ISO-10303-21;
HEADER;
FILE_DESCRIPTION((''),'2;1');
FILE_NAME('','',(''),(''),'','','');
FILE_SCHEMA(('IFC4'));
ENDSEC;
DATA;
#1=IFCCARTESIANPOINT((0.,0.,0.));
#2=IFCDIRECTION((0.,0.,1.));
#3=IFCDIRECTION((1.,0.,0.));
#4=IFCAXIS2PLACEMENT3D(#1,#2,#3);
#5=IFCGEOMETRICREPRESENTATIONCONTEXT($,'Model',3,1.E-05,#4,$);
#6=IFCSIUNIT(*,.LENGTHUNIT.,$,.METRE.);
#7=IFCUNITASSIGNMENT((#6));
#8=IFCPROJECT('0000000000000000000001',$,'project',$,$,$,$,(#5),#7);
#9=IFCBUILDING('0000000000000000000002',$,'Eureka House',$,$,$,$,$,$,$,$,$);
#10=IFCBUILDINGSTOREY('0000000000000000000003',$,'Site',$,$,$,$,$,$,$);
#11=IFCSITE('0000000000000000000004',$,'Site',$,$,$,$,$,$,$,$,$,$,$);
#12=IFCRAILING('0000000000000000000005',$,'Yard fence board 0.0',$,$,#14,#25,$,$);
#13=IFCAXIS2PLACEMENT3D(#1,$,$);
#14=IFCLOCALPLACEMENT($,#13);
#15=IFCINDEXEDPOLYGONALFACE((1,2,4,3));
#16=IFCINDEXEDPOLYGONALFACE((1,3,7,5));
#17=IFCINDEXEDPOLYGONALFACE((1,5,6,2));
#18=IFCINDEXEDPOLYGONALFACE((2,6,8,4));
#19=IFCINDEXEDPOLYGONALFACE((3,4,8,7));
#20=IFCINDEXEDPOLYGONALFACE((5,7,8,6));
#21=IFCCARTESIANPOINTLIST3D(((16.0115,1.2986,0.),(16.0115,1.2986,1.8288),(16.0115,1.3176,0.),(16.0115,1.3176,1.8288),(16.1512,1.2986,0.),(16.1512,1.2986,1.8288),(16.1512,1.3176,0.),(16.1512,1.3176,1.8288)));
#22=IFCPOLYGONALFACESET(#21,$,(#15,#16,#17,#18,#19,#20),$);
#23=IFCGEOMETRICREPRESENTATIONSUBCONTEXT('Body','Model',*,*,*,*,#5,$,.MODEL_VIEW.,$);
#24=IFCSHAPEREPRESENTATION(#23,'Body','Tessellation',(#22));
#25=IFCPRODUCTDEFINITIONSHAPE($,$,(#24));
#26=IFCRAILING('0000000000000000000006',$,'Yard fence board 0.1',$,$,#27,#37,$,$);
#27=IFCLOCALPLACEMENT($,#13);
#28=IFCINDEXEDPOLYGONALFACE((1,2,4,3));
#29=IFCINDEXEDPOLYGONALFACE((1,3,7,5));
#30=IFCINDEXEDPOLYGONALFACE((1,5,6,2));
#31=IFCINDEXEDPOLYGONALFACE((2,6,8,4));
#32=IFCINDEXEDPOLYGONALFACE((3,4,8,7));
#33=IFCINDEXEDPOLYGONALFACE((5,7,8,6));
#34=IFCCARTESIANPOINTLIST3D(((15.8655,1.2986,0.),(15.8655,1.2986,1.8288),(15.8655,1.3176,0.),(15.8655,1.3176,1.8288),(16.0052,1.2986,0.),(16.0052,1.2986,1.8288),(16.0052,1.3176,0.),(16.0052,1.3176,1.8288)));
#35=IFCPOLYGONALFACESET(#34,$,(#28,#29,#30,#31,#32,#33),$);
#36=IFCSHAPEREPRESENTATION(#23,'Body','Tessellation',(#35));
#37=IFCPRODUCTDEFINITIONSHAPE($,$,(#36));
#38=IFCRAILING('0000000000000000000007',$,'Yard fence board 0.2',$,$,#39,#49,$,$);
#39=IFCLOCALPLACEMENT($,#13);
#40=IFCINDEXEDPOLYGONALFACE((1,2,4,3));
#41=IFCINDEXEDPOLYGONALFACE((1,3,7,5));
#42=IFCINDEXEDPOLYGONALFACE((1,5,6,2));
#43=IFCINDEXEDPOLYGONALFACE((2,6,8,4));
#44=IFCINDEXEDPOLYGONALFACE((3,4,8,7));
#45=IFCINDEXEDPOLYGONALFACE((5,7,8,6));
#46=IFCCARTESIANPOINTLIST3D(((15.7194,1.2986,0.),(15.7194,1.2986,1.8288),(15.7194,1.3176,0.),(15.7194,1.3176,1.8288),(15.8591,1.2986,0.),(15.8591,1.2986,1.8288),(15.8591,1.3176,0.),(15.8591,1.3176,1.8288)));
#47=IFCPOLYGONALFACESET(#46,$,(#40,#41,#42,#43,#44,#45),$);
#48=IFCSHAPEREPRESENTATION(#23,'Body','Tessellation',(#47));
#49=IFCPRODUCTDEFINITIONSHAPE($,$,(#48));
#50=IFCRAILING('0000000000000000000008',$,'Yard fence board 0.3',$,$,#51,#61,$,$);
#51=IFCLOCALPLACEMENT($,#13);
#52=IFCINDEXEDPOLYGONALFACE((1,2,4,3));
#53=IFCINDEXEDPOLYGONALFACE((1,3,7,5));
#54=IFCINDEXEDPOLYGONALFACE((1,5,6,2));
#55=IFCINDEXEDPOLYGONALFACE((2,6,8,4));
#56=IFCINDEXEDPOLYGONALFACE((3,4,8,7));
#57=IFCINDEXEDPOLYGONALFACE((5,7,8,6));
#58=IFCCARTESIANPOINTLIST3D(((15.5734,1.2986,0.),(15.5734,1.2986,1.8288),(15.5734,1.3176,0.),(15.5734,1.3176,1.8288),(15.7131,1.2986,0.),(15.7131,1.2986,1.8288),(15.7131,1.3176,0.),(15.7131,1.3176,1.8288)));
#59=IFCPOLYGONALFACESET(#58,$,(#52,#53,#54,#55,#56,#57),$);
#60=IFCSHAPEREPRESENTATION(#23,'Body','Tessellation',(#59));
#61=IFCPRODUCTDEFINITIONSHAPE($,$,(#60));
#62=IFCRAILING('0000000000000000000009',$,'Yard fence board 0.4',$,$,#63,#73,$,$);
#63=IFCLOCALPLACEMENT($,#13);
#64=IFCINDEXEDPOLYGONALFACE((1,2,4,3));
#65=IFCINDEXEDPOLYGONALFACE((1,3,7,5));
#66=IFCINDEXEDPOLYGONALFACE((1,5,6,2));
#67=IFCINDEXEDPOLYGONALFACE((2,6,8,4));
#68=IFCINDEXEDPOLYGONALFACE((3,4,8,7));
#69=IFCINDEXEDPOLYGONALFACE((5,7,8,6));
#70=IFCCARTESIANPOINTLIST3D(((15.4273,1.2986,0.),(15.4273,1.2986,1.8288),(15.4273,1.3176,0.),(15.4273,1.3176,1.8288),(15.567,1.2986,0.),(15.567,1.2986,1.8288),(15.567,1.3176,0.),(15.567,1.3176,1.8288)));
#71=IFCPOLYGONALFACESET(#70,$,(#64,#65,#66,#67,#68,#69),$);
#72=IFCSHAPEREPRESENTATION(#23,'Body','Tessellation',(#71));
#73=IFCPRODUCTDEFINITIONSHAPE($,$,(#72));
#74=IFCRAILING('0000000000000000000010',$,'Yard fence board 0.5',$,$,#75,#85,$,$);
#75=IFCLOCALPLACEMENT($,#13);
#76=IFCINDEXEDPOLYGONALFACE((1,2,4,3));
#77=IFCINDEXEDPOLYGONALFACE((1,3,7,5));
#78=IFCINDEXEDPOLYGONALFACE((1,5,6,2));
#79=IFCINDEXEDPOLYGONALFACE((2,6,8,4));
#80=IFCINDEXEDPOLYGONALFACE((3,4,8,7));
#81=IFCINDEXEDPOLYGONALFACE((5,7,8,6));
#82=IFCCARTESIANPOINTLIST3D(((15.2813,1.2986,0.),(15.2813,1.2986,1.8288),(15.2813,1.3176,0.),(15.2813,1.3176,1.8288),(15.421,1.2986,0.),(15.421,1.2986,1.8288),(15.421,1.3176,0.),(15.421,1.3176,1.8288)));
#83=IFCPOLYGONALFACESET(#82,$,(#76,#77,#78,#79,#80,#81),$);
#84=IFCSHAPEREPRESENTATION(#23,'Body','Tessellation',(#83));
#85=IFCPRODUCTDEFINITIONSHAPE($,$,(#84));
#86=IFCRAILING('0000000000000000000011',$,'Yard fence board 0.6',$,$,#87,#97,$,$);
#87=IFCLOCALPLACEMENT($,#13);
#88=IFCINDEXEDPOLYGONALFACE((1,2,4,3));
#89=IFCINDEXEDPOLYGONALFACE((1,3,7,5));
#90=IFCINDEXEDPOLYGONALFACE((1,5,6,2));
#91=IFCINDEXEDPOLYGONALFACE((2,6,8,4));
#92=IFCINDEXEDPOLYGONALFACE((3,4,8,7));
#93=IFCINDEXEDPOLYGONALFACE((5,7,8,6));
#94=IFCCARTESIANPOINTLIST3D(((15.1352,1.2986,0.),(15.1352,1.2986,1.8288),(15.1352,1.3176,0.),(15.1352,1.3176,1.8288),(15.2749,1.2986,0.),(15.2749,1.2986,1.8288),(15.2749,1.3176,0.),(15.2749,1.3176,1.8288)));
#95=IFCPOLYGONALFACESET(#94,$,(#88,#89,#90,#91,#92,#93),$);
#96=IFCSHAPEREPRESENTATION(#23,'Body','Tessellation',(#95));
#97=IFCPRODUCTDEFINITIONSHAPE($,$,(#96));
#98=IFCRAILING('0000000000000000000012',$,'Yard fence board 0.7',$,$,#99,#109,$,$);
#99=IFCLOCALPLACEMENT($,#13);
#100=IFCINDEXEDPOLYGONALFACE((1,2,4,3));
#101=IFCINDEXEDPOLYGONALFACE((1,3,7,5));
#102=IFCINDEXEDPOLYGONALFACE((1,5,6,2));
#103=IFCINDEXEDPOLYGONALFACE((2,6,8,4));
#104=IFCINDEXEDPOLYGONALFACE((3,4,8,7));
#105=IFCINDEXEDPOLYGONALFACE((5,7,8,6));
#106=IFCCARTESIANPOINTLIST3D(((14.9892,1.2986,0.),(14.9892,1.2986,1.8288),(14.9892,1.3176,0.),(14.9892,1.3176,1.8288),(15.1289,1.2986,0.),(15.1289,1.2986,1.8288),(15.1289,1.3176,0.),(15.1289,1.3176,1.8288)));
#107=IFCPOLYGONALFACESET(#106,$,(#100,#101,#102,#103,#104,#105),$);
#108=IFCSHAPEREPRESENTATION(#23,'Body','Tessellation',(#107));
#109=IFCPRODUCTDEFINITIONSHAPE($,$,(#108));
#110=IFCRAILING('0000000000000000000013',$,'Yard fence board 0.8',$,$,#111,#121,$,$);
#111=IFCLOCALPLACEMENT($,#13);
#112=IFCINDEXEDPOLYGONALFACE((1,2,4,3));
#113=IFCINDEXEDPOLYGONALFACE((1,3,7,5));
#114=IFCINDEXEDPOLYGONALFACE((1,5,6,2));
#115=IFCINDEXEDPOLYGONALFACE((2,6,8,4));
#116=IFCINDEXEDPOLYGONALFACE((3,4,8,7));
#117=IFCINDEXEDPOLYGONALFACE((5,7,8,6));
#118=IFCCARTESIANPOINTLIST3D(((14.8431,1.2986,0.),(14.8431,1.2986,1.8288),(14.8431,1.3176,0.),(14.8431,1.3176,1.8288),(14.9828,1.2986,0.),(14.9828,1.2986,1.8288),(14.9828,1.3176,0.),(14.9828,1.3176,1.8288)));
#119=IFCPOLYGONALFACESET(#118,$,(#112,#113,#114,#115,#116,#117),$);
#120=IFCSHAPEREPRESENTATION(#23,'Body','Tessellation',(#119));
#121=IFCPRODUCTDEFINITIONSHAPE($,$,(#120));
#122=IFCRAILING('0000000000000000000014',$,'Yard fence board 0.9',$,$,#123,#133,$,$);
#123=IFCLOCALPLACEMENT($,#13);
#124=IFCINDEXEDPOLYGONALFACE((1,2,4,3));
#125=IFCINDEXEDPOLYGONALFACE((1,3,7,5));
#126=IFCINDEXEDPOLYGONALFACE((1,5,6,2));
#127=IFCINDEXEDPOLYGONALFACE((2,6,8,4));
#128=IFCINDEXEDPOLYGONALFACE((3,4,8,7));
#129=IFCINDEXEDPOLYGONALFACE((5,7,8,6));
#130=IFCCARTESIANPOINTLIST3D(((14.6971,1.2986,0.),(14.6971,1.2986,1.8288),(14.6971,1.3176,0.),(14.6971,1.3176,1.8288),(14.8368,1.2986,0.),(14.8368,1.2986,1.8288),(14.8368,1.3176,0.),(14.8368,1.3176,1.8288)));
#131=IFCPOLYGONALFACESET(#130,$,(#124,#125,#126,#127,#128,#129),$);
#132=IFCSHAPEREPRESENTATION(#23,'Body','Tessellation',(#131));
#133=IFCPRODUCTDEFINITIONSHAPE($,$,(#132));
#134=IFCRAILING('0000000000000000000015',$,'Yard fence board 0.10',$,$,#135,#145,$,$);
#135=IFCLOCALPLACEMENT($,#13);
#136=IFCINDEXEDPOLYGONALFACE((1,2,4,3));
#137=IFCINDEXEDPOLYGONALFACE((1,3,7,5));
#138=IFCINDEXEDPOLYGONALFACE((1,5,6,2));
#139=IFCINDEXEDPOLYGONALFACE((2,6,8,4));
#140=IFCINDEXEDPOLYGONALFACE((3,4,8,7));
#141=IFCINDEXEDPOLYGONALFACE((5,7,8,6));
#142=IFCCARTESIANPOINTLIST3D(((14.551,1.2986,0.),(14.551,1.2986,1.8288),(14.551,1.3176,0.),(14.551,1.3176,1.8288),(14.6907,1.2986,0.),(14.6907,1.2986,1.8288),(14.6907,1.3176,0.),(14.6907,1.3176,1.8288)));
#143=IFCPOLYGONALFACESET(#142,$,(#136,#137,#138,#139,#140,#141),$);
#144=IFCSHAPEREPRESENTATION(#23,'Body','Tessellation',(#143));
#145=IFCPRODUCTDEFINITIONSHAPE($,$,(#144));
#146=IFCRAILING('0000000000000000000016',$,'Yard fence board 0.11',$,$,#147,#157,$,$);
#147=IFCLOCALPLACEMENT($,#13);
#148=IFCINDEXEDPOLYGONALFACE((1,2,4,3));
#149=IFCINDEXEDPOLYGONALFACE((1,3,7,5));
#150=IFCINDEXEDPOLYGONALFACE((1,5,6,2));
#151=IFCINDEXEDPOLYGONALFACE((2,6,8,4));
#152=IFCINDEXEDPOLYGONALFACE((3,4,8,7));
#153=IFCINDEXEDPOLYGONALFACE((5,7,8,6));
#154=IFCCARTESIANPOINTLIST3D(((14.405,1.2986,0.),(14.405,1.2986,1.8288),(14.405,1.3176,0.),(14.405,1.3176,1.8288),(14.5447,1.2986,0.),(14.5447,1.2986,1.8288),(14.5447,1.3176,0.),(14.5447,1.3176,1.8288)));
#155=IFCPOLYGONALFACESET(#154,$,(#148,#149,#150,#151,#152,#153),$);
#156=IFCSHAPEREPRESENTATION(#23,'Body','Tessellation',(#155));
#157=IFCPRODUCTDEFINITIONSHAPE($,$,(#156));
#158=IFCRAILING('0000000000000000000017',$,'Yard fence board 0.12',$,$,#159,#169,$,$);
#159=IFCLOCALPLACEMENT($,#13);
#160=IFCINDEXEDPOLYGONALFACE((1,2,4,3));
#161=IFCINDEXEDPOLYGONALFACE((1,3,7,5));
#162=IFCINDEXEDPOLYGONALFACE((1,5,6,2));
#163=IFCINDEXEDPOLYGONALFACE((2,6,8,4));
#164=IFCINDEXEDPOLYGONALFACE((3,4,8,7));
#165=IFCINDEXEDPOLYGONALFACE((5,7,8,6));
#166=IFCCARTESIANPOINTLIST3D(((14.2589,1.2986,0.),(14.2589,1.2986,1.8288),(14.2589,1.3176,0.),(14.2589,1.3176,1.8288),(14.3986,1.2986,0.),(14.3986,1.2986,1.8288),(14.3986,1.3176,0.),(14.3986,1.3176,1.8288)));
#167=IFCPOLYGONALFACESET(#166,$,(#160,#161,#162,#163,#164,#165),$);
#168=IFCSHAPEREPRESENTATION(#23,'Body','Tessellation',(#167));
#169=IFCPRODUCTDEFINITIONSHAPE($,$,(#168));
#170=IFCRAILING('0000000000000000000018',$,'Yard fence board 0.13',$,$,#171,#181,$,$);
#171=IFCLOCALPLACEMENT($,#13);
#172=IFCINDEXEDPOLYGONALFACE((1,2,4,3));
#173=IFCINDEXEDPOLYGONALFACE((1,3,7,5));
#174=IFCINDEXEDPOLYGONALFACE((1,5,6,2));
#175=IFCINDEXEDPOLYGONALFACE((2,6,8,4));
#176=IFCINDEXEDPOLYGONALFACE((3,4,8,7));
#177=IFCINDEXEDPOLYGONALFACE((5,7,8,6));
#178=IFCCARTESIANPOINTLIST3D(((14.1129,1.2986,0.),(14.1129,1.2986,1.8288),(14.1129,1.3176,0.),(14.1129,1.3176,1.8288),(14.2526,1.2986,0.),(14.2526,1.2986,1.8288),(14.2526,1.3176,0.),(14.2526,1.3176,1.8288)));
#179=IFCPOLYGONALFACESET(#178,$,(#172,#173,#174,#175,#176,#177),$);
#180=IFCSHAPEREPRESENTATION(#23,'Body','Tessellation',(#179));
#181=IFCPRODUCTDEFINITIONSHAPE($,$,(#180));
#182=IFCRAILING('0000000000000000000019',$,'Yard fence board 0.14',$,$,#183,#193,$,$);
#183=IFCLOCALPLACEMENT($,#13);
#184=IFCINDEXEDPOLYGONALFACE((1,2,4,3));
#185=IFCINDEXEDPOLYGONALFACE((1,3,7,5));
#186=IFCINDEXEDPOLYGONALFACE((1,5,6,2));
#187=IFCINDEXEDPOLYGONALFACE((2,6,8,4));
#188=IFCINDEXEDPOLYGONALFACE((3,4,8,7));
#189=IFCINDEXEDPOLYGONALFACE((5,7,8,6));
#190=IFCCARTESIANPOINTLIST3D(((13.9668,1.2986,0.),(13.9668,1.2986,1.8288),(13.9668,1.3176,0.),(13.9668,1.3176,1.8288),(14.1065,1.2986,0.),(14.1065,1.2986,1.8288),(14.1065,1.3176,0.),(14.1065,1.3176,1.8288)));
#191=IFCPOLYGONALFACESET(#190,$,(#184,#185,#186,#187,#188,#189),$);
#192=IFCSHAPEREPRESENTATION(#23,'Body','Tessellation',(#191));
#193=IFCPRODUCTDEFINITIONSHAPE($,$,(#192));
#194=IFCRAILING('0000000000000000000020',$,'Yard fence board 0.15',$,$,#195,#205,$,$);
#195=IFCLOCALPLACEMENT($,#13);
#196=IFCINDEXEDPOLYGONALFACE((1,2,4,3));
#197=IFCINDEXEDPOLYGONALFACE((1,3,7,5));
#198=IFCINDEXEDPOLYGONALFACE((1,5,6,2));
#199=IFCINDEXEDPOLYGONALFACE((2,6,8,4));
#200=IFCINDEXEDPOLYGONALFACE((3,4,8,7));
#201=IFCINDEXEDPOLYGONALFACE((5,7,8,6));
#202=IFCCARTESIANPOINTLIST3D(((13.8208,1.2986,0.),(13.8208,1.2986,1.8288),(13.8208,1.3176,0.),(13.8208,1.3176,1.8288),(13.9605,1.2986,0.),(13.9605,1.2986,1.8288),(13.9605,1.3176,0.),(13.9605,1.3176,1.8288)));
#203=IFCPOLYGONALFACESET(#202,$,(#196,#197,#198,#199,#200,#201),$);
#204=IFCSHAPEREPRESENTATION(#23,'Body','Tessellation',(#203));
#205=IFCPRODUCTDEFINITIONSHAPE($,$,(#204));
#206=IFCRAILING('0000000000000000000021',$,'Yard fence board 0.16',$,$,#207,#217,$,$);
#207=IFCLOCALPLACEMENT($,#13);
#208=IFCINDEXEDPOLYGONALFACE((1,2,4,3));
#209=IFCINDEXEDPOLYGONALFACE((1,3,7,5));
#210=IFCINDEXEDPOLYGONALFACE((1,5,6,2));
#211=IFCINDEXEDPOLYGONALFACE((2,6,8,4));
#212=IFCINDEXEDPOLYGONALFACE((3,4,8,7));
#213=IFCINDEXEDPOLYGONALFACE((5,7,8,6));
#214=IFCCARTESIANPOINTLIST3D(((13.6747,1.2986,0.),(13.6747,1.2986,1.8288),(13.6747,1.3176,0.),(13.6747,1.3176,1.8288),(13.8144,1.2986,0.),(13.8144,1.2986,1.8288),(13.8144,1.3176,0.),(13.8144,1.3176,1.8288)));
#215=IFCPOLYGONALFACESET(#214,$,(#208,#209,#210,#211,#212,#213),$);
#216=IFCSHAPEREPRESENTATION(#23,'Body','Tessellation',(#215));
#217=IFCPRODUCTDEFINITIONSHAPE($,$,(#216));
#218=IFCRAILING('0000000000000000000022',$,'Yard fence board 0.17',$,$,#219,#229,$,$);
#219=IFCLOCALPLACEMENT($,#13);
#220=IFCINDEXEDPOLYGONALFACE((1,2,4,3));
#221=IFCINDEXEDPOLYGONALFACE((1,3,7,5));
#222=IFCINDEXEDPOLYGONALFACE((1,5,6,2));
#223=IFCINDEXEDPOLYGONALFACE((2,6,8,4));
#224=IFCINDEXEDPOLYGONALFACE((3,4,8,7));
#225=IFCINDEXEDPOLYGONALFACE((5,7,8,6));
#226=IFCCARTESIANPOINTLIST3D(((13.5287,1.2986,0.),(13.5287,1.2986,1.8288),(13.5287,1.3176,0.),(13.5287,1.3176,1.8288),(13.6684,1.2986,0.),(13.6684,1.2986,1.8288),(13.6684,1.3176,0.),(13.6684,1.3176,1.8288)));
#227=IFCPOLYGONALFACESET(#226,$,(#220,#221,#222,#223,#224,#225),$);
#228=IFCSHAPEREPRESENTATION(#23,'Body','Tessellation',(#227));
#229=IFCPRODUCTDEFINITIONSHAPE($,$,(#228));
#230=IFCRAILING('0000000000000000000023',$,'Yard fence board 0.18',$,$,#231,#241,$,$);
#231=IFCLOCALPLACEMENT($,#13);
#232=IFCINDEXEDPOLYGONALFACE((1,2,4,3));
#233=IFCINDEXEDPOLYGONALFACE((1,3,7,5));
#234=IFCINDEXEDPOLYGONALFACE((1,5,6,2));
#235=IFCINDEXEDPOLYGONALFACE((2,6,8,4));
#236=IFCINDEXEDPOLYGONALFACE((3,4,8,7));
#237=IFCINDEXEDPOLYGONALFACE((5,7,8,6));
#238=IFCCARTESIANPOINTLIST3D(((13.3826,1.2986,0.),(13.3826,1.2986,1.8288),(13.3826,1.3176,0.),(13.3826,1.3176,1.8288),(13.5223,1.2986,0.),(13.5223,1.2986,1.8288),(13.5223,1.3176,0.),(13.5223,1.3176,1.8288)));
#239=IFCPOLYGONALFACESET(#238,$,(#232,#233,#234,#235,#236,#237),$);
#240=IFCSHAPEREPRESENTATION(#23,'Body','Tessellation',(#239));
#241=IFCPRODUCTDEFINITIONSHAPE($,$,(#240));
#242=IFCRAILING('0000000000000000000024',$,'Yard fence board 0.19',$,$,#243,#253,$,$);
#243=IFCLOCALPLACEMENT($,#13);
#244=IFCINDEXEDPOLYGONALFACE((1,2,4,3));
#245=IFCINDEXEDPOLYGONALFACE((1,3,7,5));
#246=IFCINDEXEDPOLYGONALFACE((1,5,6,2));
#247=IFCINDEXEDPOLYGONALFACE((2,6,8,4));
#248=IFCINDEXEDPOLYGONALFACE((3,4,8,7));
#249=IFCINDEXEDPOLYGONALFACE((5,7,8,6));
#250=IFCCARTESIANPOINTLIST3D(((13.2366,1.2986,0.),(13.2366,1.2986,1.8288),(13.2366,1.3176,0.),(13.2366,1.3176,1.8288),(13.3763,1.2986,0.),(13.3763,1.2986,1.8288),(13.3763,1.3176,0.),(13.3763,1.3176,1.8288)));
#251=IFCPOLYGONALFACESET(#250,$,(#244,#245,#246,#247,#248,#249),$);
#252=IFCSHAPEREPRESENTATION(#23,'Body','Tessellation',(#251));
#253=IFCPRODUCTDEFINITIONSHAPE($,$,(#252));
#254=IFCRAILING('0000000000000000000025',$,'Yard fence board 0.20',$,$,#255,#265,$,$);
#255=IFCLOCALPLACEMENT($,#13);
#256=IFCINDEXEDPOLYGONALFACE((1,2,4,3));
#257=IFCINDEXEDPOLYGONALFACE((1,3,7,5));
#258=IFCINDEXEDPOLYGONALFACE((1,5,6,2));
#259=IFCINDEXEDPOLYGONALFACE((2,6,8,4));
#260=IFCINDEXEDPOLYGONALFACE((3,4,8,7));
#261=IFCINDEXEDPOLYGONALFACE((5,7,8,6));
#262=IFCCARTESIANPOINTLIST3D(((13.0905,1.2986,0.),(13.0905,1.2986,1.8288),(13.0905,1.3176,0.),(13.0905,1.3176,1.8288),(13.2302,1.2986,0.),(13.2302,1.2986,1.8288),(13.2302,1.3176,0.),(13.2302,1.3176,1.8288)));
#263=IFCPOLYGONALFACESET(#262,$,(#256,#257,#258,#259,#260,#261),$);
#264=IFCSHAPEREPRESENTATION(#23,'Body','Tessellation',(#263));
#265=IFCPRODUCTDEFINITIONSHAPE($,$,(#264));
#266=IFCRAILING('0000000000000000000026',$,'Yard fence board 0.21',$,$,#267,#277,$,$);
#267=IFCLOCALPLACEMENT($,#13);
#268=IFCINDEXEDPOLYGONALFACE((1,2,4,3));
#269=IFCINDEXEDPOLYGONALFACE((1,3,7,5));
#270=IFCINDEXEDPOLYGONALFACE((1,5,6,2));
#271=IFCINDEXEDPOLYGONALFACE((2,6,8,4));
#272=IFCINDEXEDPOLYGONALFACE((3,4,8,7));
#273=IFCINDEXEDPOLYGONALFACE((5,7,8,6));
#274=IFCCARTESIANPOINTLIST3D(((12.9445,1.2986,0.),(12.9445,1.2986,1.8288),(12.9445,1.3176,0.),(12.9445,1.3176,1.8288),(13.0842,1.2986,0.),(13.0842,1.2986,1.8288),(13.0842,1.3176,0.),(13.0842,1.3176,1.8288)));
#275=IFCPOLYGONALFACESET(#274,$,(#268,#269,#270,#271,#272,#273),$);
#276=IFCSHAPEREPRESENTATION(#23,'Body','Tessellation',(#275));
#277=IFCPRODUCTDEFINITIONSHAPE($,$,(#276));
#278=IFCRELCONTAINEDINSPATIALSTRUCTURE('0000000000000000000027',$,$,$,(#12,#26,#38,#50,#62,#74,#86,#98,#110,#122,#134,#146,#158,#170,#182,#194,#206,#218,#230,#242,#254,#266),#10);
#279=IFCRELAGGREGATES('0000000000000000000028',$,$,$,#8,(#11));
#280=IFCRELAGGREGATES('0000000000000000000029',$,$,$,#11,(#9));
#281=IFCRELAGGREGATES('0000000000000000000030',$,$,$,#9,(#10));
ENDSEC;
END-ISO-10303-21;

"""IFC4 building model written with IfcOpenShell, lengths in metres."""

from ifc_helpers import new_model, si_unit, frame, origin, origin_with_axes, origin_2d, place, context, subcontext, project, spatial, rectangle, extrude, element, save


model = new_model("IFC4")

# Units and contexts
model_context = context("Model", 3, precision=1e-05, world=origin_with_axes())
body_context = subcontext(model_context, "Body", "Model", "MODEL_VIEW")
ifc_project = project(units=[si_unit("LENGTHUNIT", "METRE")], contexts=[model_context])

# Site, building, storey
site = spatial("IfcSite", under=ifc_project, Name="Site")
building = spatial("IfcBuilding", under=site, Name="Eureka House")
storey = spatial("IfcBuildingStorey", under=building, Name="Site")

# Railings
for number, where, z_axis, x_axis, name in (
    (1, (16.0814, 1.3081, 0.0), (0.0, 0.0, 1.0), (1.0, 0.0, 0.0), "Yard fence board 0.0"),
    (2, (15.9353, 1.3081, 0.0), (0.0, 0.0, 1.0), (1.0, 0.0, 0.0), "Yard fence board 0.1"),
    (3, (15.7893, 1.3081, 0.0), (0.0, 0.0, 1.0), (1.0, 0.0, 0.0), "Yard fence board 0.2"),
    (4, (15.6432, 1.3081, 0.0), (0.0, 0.0, 1.0), (1.0, 0.0, 0.0), "Yard fence board 0.3"),
    (5, (15.4972, 1.3081, 0.0), (0.0, 0.0, 1.0), (1.0, 0.0, 0.0), "Yard fence board 0.4"),
    (6, (15.3511, 1.3081, 0.0), (0.0, 0.0, 1.0), (1.0, 0.0, 0.0), "Yard fence board 0.5"),
    (7, (15.2051, 1.3081, 0.0), (0.0, 0.0, 1.0), (1.0, 0.0, 0.0), "Yard fence board 0.6"),
    (8, (15.059, 1.3081, 0.0), (0.0, 0.0, 1.0), (1.0, 0.0, 0.0), "Yard fence board 0.7"),
    (9, (14.913, 1.3081, 0.0), (0.0, 0.0, 1.0), (1.0, 0.0, 0.0), "Yard fence board 0.8"),
    (10, (14.7669, 1.3081, 0.0), (0.0, 0.0, 1.0), (1.0, 0.0, 0.0), "Yard fence board 0.9"),
    (11, (14.6209, 1.3081, 0.0), (0.0, 0.0, 1.0), (1.0, 0.0, 0.0), "Yard fence board 0.10"),
    (12, (14.4748, 1.3081, 0.0), (0.0, 0.0, 1.0), (1.0, 0.0, 0.0), "Yard fence board 0.11"),
    (13, (14.3288, 1.3081, 0.0), (0.0, 0.0, 1.0), (1.0, 0.0, 0.0), "Yard fence board 0.12"),
    (14, (14.1827, 1.3081, 0.0), (0.0, 0.0, 1.0), (1.0, 0.0, 0.0), "Yard fence board 0.13"),
    (15, (14.0367, 1.3081, 0.0), (0.0, 0.0, 1.0), (1.0, 0.0, 0.0), "Yard fence board 0.14"),
    (16, (13.8906, 1.3081, 0.0), (0.0, 0.0, 1.0), (1.0, 0.0, 0.0), "Yard fence board 0.15"),
    (17, (13.7446, 1.3081, 0.0), (0.0, 0.0, 1.0), (1.0, 0.0, 0.0), "Yard fence board 0.16"),
    (18, (13.5985, 1.3081, 0.0), (0.0, 0.0, 1.0), (1.0, 0.0, 0.0), "Yard fence board 0.17"),
    (19, (13.4525, 1.3081, 0.0), (0.0, 0.0, 1.0), (1.0, 0.0, 0.0), "Yard fence board 0.18"),
    (20, (13.3064, 1.3081, 0.0), (0.0, 0.0, 1.0), (1.0, 0.0, 0.0), "Yard fence board 0.19"),
    (21, (13.1604, 1.3081, 0.0), (0.0, 0.0, 1.0), (1.0, 0.0, 0.0), "Yard fence board 0.20"),
    (22, (13.0143, 1.3081, 0.0), (0.0, 0.0, 1.0), (1.0, 0.0, 0.0), "Yard fence board 0.21"),
):
    element("IfcRailing", number, at=place(None, frame(where, z_axis=z_axis, x_axis=x_axis)), inside=storey, Name=name, context=body_context, shape_type="SweptSolid", body=[
        extrude(rectangle(XDim=0.1397, YDim=0.0191, at=origin_2d()), origin(), (0.0, 0.0, 1.0), 1.8288),
    ])

save(model, "model.ifc")
